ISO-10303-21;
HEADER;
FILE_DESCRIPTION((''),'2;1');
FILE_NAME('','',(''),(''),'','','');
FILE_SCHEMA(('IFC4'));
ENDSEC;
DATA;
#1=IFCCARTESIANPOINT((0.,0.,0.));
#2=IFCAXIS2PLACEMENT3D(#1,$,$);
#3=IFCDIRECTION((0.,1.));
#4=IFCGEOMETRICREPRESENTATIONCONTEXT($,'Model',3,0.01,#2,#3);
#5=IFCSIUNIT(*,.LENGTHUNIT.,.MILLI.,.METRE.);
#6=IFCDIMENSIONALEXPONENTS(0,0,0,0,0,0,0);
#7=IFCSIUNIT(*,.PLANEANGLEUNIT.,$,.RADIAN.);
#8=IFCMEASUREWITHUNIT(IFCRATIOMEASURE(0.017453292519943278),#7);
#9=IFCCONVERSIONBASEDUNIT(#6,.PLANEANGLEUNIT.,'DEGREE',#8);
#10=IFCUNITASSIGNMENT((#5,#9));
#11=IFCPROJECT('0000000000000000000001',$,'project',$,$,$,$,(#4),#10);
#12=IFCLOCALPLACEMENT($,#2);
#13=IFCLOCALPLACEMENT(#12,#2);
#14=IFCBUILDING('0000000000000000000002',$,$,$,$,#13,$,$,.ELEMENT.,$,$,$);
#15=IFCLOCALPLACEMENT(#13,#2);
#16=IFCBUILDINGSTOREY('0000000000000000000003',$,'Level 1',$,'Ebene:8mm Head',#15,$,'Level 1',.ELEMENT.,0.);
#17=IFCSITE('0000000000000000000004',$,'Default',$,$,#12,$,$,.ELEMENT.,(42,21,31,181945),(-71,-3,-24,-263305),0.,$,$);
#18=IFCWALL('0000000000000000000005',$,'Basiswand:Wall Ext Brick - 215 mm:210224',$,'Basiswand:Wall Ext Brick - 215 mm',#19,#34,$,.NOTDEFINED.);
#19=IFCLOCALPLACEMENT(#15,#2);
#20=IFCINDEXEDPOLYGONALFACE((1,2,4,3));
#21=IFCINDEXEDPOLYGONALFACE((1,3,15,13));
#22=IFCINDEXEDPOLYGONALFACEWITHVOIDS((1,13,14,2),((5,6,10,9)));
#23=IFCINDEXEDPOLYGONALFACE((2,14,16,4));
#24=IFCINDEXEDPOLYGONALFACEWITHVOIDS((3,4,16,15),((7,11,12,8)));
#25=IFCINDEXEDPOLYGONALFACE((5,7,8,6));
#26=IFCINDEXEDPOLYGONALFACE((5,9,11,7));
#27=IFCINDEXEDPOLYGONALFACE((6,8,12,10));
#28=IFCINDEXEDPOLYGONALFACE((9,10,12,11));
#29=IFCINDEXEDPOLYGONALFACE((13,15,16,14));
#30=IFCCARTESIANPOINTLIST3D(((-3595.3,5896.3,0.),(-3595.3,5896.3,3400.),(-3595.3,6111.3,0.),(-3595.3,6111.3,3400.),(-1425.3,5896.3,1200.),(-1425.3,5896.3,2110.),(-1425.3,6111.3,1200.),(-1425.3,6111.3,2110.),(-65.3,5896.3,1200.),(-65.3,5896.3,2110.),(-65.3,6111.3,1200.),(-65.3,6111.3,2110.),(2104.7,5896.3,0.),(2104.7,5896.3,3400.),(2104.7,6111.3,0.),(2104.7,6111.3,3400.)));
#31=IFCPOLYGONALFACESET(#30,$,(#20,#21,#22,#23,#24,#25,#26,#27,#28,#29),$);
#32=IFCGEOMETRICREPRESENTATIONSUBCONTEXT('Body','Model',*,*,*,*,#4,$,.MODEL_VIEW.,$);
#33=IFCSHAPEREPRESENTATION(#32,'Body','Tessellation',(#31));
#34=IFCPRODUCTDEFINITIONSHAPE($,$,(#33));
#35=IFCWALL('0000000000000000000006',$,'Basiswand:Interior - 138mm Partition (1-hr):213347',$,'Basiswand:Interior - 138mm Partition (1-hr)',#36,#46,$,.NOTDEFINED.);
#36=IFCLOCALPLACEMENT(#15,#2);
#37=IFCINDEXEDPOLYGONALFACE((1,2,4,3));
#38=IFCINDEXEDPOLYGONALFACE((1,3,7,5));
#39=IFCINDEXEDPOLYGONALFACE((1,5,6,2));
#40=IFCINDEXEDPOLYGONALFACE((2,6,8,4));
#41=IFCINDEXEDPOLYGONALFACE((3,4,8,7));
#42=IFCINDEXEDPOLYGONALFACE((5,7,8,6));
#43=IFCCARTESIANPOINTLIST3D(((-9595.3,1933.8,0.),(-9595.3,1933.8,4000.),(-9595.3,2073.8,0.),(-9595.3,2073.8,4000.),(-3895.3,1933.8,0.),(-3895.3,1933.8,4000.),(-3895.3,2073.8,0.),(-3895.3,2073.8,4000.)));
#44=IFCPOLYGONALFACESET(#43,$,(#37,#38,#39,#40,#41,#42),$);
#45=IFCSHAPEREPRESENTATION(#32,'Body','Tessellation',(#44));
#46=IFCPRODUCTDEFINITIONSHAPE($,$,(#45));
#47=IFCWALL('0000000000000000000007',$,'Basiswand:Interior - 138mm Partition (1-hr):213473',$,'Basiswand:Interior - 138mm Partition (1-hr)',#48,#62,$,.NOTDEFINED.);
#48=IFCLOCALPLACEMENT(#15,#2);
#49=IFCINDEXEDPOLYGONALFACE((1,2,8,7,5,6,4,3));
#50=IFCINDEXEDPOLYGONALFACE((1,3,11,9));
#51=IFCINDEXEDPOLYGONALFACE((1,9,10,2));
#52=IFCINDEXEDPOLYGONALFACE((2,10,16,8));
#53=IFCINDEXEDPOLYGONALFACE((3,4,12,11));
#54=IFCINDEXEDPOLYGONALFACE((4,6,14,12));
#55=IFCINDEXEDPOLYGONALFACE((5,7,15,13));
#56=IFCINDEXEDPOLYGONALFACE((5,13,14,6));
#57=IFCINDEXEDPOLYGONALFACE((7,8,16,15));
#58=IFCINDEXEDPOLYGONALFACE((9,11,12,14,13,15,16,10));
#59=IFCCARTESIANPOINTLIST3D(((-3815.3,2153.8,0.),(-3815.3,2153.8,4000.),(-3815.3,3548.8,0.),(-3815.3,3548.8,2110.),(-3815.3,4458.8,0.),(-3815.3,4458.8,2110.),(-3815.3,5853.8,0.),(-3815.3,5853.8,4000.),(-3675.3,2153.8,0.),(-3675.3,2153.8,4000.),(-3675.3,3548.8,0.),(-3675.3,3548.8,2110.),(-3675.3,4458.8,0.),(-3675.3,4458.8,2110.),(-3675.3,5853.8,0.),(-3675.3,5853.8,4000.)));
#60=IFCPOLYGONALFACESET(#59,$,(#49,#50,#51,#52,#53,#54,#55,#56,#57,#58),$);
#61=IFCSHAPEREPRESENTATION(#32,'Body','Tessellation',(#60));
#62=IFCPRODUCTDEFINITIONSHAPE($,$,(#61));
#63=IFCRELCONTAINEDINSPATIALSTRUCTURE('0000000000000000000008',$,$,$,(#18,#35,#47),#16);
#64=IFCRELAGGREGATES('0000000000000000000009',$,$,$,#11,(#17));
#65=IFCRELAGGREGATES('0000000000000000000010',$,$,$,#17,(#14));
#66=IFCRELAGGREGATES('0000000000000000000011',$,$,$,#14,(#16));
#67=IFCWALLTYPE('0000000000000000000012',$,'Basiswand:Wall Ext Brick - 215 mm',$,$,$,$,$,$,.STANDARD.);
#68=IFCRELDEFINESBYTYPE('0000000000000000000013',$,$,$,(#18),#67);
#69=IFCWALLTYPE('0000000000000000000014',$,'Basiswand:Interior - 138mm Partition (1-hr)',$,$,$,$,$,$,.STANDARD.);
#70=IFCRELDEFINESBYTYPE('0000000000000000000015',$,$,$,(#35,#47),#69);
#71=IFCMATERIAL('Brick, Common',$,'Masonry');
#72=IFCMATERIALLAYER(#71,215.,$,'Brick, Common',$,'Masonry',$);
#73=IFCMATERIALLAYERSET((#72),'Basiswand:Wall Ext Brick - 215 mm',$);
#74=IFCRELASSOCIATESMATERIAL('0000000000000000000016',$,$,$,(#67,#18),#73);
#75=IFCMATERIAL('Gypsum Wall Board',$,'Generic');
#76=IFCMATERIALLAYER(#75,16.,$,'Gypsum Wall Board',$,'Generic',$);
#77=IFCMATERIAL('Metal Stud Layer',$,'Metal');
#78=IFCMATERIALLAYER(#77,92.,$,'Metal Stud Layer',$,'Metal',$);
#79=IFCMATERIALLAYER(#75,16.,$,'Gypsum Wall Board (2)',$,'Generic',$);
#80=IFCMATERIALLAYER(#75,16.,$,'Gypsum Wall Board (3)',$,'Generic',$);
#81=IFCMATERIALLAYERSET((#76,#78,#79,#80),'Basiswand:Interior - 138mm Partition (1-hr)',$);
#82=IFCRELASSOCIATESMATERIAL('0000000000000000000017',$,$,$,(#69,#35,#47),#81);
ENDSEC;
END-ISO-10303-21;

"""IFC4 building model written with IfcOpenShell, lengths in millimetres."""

from ifc_helpers import new_model, entity, si_unit, converted_unit, direction, frame, frame_2d, origin, place, context, subcontext, project, spatial, rectangle, extrude, material, layer, layer_set, layer_usage, type_object, element, save


model = new_model("IFC4")

# Units and contexts
model_context = context("Model", 3, precision=0.01, world=origin(), true_north=direction((0.0, 1.0)))
body_context = subcontext(model_context, "Body", "Model", "MODEL_VIEW")
ifc_project = project(units=[si_unit("LENGTHUNIT", "METRE", prefix="MILLI"), converted_unit("PLANEANGLEUNIT", "DEGREE", entity("IfcRatioMeasure", 0.017453292519943278), si_unit("PLANEANGLEUNIT", "RADIAN"), dimensions=[0, 0, 0, 0, 0, 0, 0])], contexts=[model_context])

# Site, building, storey
site_placement = place(None, origin())
site = spatial("IfcSite", under=ifc_project, at=site_placement, Name="Default", CompositionType="ELEMENT", RefLatitude=(42, 21, 31, 181945), RefLongitude=(-71, -3, -24, -263305), RefElevation=0.0)
building_placement = place(site_placement, origin())
building = spatial("IfcBuilding", under=site, at=building_placement, CompositionType="ELEMENT")
storey_placement = place(building_placement, origin())
storey = spatial("IfcBuildingStorey", under=building, at=storey_placement, Name="Level 1", ObjectType="Ebene:8mm Head", LongName="Level 1", CompositionType="ELEMENT", Elevation=0.0)

# Wall, opening
ifc_material_1 = material(Name="Brick, Common", Category="Masonry")
ifc_layer_1 = layer(ifc_material_1, 215.0, Name="Brick, Common", Category="Masonry")
ifc_layer_set_1 = layer_set([ifc_layer_1], Name="Basiswand:Wall Ext Brick - 215 mm")
wall_type_1 = type_object("IfcWallType", Name="Basiswand:Wall Ext Brick - 215 mm", PredefinedType="STANDARD", material=ifc_layer_set_1)
ifc_layer_usage_1 = layer_usage(ifc_layer_set_1, "AXIS2", "NEGATIVE", 107.5)
wall_1_placement = place(storey_placement, frame((-3595.3, 6003.8, 0.0)))
wall_1 = element("IfcWall", 1, at=wall_1_placement, inside=storey, type_object=wall_type_1, material=ifc_layer_usage_1, Name="Basiswand:Wall Ext Brick - 215 mm:210224", ObjectType="Basiswand:Wall Ext Brick - 215 mm", PredefinedType="NOTDEFINED", context=body_context, shape_type="SweptSolid", body=[
    extrude(rectangle(XDim=5700.0, YDim=215.0, at=frame_2d((2850.0, 0.0), x_axis=(-1.0, 0.0))), origin(), (0.0, 0.0, 1.0), 3400.0),
])
opening_1_placement = place(wall_1_placement, frame((2170.0, -107.5, 1200.0)))
element("IfcOpeningElement", 2, at=opening_1_placement, cuts=wall_1, PredefinedType="OPENING", context=body_context, shape_type="SweptSolid", body=[
    extrude(rectangle(XDim=910.0, YDim=1360.0, at=frame_2d((455.0, 680.0), x_axis=(-1.0, 0.0))), frame((0.0, 0.0, 0.0), z_axis=(0.0, 1.0, 0.0), x_axis=(0.0, 0.0, 1.0)), (0.0, 0.0, 1.0), 215.0),
])

# Wall
ifc_material_2 = material(Name="Gypsum Wall Board", Category="Generic")
ifc_layer_2 = layer(ifc_material_2, 16.0, Name="Gypsum Wall Board", Category="Generic")
ifc_material_3 = material(Name="Metal Stud Layer", Category="Metal")
ifc_layer_3 = layer(ifc_material_3, 92.0, Name="Metal Stud Layer", Category="Metal")
ifc_layer_4 = layer(ifc_material_2, 16.0, Name="Gypsum Wall Board (2)", Category="Generic")
ifc_layer_5 = layer(ifc_material_2, 16.0, Name="Gypsum Wall Board (3)", Category="Generic")
ifc_layer_set_2 = layer_set([ifc_layer_2, ifc_layer_3, ifc_layer_4, ifc_layer_5], Name="Basiswand:Interior - 138mm Partition (1-hr)")
ifc_layer_usage_2 = layer_usage(ifc_layer_set_2, "AXIS2", "NEGATIVE", 70.0)
wall_type_2 = type_object("IfcWallType", Name="Basiswand:Interior - 138mm Partition (1-hr)", PredefinedType="STANDARD", material=ifc_layer_set_2)
wall_2_placement = place(storey_placement, frame((-9595.3, 2003.8, 0.0)))
element("IfcWall", 3, at=wall_2_placement, inside=storey, type_object=wall_type_2, material=ifc_layer_usage_2, Name="Basiswand:Interior - 138mm Partition (1-hr):213347", ObjectType="Basiswand:Interior - 138mm Partition (1-hr)", PredefinedType="NOTDEFINED", context=body_context, shape_type="SweptSolid", body=[
    extrude(rectangle(XDim=5700.0, YDim=140.0, at=frame_2d((2850.0, 0.0), x_axis=(-1.0, 0.0))), origin(), (0.0, 0.0, 1.0), 4000.0),
])

# Wall, opening
ifc_layer_usage_3 = layer_usage(ifc_layer_set_2, "AXIS2", "NEGATIVE", 70.0)
wall_3_placement = place(storey_placement, frame((-3745.3, 2153.8, 0.0), z_axis=(0.0, 0.0, 1.0), x_axis=(0.0, 1.0, 0.0)))
wall_3 = element("IfcWall", 4, at=wall_3_placement, inside=storey, type_object=wall_type_2, material=ifc_layer_usage_3, Name="Basiswand:Interior - 138mm Partition (1-hr):213473", ObjectType="Basiswand:Interior - 138mm Partition (1-hr)", PredefinedType="NOTDEFINED", context=body_context, shape_type="SweptSolid", body=[
    extrude(rectangle(XDim=3700.0, YDim=140.0, at=frame_2d((1850.0, 0.0), x_axis=(1.0, 0.0))), origin(), (0.0, 0.0, 1.0), 4000.0),
])
opening_2_placement = place(wall_3_placement, frame((1395.0, -70.0, 0.0)))
element("IfcOpeningElement", 5, at=opening_2_placement, cuts=wall_3, PredefinedType="OPENING", context=body_context, shape_type="SweptSolid", body=[
    extrude(rectangle(XDim=2110.0, YDim=910.0, at=frame_2d((1055.0, 455.0), x_axis=(1.0, 0.0))), frame((0.0, 0.0, 0.0), z_axis=(0.0, 1.0, 0.0), x_axis=(0.0, 0.0, 1.0)), (0.0, 0.0, 1.0), 140.0),
])

save(model, "model.ifc")
